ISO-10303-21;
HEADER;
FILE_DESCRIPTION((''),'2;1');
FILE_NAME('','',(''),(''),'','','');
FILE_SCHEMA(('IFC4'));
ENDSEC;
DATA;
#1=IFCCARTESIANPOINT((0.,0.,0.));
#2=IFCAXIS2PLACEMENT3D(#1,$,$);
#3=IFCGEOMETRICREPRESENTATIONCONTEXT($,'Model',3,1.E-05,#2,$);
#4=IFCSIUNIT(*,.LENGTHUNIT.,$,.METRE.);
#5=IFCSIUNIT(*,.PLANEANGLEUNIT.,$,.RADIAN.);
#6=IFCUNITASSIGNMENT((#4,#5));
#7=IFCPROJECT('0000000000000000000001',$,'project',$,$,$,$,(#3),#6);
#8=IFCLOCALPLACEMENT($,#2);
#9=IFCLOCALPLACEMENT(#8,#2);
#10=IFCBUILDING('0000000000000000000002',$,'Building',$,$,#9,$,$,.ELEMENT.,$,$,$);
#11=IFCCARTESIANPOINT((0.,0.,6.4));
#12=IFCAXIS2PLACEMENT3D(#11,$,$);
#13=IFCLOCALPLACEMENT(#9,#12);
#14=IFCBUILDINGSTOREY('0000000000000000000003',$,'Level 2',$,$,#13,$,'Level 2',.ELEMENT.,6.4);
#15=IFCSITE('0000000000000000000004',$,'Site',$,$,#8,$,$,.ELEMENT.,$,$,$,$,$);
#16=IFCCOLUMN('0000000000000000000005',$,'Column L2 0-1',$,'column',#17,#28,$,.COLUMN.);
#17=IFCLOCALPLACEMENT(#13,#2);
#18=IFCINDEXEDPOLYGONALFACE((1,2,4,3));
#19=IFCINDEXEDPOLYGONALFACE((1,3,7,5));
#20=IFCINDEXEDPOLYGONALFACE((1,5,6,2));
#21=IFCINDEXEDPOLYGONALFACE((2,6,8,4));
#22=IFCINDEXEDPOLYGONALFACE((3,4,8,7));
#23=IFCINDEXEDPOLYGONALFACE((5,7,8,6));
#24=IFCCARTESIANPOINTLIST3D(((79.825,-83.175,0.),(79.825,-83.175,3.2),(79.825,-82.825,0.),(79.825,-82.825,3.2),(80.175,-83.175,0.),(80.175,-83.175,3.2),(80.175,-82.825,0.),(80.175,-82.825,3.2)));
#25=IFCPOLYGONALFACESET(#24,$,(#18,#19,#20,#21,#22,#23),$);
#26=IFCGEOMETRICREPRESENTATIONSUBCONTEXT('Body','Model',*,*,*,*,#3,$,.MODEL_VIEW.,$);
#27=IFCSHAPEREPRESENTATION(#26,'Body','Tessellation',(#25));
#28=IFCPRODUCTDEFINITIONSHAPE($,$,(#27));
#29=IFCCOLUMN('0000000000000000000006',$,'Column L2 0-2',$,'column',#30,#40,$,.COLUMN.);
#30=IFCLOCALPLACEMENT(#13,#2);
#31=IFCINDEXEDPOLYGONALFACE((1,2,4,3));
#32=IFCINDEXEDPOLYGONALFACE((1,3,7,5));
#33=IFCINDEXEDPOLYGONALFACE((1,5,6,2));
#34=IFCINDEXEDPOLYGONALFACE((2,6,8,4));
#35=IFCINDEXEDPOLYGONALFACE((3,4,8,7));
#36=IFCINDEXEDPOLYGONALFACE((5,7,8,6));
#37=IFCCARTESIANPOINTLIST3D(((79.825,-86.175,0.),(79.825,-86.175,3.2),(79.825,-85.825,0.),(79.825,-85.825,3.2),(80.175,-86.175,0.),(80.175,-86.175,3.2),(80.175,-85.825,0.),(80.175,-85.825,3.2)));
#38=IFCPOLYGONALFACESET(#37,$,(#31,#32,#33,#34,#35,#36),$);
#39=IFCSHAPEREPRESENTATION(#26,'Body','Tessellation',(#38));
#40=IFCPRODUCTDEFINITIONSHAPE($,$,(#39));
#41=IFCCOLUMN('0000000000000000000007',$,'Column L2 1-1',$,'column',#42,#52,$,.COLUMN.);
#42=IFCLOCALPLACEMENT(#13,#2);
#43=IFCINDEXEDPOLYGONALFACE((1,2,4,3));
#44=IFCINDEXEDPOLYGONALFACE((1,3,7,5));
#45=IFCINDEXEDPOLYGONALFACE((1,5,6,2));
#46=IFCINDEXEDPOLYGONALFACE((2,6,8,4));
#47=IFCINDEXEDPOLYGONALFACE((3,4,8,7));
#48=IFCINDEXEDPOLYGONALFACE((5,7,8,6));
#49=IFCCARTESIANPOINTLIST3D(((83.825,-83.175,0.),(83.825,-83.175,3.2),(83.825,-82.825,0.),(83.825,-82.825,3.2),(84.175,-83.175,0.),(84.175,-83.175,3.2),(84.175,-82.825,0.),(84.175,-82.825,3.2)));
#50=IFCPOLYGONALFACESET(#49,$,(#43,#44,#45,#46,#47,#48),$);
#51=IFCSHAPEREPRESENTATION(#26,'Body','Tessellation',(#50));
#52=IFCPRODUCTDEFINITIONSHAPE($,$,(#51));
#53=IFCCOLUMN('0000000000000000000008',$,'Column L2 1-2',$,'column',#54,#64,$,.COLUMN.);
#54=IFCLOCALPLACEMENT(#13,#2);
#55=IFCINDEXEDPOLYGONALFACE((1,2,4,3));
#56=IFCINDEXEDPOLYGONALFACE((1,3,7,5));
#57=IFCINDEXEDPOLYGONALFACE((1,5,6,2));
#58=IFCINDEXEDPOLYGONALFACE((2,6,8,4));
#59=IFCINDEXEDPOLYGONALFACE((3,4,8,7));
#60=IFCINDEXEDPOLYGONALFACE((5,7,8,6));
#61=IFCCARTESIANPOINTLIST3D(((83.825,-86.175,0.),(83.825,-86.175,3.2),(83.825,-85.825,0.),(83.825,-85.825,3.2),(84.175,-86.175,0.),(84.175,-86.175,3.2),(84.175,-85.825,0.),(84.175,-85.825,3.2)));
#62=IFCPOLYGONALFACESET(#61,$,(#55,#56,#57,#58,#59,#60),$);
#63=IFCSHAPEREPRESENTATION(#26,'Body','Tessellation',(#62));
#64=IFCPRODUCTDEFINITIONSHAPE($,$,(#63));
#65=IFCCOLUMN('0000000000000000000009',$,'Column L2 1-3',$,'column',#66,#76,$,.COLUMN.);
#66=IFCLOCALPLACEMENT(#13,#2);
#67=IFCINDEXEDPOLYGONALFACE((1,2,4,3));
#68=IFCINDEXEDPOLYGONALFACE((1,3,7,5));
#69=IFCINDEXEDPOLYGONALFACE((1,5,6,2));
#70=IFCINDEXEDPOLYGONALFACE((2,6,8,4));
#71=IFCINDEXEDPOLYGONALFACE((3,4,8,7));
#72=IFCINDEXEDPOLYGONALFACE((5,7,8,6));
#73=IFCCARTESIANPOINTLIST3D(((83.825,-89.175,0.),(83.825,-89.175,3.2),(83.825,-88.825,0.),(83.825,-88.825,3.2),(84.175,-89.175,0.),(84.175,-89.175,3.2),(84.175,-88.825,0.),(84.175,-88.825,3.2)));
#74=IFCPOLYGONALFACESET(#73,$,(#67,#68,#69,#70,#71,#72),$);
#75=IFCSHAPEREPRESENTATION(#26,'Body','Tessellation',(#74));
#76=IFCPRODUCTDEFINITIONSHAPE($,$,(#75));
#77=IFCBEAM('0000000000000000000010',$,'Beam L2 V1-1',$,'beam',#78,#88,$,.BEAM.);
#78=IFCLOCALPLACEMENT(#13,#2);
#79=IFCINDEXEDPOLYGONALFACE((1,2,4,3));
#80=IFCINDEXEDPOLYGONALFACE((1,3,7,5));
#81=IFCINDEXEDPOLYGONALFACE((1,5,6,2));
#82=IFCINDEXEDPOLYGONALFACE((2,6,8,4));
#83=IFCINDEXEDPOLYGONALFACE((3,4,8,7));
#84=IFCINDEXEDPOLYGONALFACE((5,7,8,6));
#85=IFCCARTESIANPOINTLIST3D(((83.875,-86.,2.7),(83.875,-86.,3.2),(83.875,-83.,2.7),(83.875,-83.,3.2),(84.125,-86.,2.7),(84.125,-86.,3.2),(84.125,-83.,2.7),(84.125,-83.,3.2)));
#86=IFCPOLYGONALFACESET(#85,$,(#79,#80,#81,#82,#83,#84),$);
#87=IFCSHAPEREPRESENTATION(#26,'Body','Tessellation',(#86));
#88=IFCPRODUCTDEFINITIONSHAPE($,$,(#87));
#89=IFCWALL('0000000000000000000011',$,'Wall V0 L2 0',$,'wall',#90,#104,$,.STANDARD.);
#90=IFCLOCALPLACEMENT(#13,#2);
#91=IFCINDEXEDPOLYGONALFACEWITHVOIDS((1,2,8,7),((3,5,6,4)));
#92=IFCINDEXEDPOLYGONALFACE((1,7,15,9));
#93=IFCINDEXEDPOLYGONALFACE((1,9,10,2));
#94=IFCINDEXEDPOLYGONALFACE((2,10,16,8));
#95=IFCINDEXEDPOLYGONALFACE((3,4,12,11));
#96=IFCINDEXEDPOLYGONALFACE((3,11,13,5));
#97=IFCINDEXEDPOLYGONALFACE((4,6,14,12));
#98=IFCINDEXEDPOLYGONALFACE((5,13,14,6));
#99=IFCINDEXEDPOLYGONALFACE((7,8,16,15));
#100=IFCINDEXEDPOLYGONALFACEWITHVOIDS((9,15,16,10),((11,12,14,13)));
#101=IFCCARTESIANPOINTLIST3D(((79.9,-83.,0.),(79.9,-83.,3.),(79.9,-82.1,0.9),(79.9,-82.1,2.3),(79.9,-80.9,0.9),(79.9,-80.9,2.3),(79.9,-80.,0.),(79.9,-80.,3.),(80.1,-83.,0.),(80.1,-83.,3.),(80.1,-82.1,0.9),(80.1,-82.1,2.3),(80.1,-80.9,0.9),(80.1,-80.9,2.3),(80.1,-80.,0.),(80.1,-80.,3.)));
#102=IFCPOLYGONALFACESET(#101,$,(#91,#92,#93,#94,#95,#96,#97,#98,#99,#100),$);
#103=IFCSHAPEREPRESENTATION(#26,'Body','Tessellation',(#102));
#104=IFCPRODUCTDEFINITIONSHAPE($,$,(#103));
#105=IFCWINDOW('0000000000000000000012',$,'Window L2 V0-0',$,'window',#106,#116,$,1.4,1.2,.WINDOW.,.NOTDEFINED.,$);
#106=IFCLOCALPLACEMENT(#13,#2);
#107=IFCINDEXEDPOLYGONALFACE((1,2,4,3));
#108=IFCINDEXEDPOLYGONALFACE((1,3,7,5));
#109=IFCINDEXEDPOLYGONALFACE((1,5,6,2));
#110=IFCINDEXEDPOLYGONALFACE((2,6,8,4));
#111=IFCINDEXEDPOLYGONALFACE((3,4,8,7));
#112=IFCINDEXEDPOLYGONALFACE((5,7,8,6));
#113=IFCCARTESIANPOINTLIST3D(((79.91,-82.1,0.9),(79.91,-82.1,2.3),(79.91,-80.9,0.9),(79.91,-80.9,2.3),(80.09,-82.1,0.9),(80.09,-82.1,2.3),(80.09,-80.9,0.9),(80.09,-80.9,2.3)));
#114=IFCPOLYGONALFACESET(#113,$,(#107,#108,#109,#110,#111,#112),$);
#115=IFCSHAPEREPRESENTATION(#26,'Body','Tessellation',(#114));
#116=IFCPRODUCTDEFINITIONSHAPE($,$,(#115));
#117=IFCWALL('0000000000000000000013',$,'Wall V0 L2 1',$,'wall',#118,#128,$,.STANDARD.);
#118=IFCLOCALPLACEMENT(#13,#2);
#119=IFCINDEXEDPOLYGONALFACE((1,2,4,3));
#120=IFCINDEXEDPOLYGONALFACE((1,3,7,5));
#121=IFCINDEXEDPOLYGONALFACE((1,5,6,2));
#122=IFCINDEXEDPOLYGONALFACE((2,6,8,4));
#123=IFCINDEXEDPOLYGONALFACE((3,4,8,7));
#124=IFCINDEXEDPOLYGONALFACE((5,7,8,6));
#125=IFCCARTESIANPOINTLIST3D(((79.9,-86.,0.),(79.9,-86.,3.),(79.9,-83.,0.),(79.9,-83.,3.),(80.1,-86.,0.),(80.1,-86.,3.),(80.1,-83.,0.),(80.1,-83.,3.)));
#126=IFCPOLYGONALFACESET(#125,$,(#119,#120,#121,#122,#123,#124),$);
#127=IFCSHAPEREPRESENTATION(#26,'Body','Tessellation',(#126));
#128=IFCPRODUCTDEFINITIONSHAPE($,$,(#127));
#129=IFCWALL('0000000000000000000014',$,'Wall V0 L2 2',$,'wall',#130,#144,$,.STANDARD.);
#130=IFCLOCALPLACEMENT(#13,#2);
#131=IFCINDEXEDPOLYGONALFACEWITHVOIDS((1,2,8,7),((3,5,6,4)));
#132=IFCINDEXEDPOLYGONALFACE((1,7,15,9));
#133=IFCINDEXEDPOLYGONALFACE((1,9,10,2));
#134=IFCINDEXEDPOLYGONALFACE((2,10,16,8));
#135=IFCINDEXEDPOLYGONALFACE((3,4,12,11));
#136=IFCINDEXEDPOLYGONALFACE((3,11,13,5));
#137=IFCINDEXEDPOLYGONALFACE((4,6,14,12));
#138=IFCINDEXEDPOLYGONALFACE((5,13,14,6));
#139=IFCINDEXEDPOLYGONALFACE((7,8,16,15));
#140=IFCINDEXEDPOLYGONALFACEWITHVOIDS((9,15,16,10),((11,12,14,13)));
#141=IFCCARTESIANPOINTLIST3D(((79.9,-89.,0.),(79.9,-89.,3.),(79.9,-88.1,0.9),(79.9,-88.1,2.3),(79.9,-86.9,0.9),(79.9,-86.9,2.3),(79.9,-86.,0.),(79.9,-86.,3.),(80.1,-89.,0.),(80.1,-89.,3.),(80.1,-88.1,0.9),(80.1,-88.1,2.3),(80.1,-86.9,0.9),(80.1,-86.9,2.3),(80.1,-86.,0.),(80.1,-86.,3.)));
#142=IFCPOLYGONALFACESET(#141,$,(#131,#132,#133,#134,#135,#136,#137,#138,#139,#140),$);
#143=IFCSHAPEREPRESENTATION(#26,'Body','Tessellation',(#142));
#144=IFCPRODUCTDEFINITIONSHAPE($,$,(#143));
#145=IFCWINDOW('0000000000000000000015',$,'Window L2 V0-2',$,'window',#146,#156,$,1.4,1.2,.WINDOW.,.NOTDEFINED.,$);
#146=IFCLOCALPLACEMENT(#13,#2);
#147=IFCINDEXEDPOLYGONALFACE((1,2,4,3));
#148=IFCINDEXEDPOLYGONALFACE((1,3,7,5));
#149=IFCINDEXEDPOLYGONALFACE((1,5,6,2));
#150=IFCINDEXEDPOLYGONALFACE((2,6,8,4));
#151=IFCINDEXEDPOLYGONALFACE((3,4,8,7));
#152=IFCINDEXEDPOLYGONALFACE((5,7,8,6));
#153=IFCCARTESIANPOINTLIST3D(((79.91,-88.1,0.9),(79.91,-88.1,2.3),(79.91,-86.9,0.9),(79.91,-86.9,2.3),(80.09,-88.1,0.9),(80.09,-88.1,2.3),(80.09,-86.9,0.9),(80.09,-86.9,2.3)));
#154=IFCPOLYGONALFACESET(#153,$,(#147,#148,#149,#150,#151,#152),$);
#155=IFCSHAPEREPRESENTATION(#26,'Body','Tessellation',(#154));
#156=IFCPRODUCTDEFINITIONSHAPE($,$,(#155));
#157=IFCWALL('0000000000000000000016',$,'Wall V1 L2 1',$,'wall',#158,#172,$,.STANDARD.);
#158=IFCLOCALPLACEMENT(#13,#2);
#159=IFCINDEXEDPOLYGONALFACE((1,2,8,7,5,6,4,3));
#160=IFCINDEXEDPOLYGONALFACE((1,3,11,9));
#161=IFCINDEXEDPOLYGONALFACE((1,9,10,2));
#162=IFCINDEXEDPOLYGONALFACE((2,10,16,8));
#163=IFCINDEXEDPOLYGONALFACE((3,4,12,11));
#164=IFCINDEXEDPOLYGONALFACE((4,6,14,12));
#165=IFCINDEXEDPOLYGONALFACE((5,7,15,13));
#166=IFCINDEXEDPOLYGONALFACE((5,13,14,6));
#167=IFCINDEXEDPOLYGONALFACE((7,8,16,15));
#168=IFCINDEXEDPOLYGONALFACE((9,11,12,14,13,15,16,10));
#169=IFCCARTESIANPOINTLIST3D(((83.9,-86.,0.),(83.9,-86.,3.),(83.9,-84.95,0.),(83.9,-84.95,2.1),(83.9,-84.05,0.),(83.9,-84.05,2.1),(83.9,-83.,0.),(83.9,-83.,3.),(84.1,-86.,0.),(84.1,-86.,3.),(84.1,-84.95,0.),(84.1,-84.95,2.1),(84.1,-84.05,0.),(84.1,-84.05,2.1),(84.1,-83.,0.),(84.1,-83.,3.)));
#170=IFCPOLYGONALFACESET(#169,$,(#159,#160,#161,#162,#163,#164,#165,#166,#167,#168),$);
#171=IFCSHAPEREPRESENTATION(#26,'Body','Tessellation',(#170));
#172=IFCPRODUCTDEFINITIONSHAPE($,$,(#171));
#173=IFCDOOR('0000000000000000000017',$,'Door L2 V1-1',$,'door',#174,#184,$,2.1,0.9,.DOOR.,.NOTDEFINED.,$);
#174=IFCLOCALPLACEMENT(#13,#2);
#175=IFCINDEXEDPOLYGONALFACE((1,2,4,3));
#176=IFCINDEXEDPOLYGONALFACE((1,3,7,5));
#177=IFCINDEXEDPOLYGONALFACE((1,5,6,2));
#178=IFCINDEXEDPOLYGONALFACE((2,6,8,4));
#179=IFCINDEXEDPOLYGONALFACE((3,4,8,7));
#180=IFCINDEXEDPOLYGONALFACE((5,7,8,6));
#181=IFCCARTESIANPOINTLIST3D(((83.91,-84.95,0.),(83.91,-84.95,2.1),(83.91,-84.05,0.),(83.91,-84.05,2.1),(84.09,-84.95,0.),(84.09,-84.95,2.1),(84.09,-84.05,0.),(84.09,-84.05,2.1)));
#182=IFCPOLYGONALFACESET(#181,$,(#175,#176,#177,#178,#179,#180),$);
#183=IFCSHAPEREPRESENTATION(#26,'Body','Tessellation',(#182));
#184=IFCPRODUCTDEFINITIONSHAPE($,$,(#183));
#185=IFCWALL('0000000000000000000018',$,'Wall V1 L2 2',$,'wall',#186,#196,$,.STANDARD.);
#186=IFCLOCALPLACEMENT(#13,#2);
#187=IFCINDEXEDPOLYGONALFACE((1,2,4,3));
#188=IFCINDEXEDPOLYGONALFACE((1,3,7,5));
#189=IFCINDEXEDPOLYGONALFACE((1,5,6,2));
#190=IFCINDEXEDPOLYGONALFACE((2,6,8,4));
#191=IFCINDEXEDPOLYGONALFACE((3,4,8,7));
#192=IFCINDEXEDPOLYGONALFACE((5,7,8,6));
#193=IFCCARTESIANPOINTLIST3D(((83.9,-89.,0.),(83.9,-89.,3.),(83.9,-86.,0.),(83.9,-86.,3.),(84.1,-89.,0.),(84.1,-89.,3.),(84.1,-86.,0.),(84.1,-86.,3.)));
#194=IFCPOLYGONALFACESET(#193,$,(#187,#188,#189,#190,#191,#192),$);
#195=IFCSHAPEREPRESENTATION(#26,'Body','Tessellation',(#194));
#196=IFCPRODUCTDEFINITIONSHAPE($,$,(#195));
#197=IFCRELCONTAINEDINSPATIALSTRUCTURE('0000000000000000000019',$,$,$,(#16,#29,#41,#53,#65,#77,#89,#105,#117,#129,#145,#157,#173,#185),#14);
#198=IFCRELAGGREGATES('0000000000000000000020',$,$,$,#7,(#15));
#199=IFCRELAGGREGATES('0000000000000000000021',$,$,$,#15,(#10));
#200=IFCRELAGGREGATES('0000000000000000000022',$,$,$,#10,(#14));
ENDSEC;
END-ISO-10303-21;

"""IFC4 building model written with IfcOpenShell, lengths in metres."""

from ifc_helpers import new_model, si_unit, frame, frame_2d, origin, origin_2d, place, context, subcontext, project, spatial, rectangle, extrude, element, fill, save


model = new_model("IFC4")

# Units and contexts
model_context = context("Model", 3, precision=1e-05, world=origin())
body_context = subcontext(model_context, "Body", "Model", "MODEL_VIEW")
ifc_project = project(units=[si_unit("LENGTHUNIT", "METRE"), si_unit("PLANEANGLEUNIT", "RADIAN")], contexts=[model_context])

# Site, building, storey
site_placement = place(None, origin())
site = spatial("IfcSite", under=ifc_project, at=site_placement, Name="Site", CompositionType="ELEMENT")
building_placement = place(site_placement, origin())
building = spatial("IfcBuilding", under=site, at=building_placement, Name="Building", CompositionType="ELEMENT")
storey_placement = place(building_placement, frame((0.0, 0.0, 6.4)))
storey = spatial("IfcBuildingStorey", under=building, at=storey_placement, Name="Level 2", LongName="Level 2", CompositionType="ELEMENT", Elevation=6.4)

# Columns
for number, where, name in (
    (1, (80.0, -83.0, 0.0), "Column L2 0-1"),
    (2, (80.0, -86.0, 0.0), "Column L2 0-2"),
    (3, (84.0, -83.0, 0.0), "Column L2 1-1"),
    (4, (84.0, -86.0, 0.0), "Column L2 1-2"),
    (5, (84.0, -89.0, 0.0), "Column L2 1-3"),
):
    element("IfcColumn", number, at=place(storey_placement, frame(where)), inside=storey, Name=name, ObjectType="column", PredefinedType="COLUMN", context=body_context, shape_type="SweptSolid", body=[
        extrude(rectangle(XDim=0.35, YDim=0.35, at=origin_2d()), origin(), (0.0, 0.0, 1.0), 3.2),
    ])

# Beam
beam_placement = place(storey_placement, frame((84.0, -83.0, 2.95), z_axis=(0.0, -1.0, 0.0), x_axis=(0.0, 0.0, 1.0)))
element("IfcBeam", 6, at=beam_placement, inside=storey, Name="Beam L2 V1-1", ObjectType="beam", PredefinedType="BEAM", context=body_context, shape_type="SweptSolid", body=[
    extrude(rectangle(XDim=0.5, YDim=0.25, at=origin_2d()), origin(), (0.0, 0.0, 1.0), 3.0),
])

# Wall, opening, window
wall_1_placement = place(storey_placement, frame((80.0, -80.0, 0.0), z_axis=(0.0, 0.0, 1.0), x_axis=(0.0, -1.0, 0.0)))
wall_1 = element("IfcWall", 7, at=wall_1_placement, inside=storey, Name="Wall V0 L2 0", ObjectType="wall", PredefinedType="STANDARD", context=body_context, shape_type="SweptSolid", body=[
    extrude(rectangle(XDim=3.0, YDim=0.2, at=frame_2d((1.5, 0.0))), origin(), (0.0, 0.0, 1.0), 3.0),
])
opening_1_placement = place(storey_placement, frame((80.0, -81.5, 0.9), z_axis=(0.0, 0.0, 1.0), x_axis=(0.0, -1.0, 0.0)))
opening_1 = element("IfcOpeningElement", 8, at=opening_1_placement, cuts=wall_1, ObjectType="Opening", PredefinedType="OPENING", context=body_context, shape_type="SweptSolid", body=[
    extrude(rectangle(XDim=1.2, YDim=0.22, at=origin_2d()), origin(), (0.0, 0.0, 1.0), 1.4),
])
window_1_placement = place(storey_placement, frame((80.0, -81.5, 0.9), z_axis=(0.0, 0.0, 1.0), x_axis=(0.0, -1.0, 0.0)))
window_1 = element("IfcWindow", 9, at=window_1_placement, inside=storey, Name="Window L2 V0-0", ObjectType="window", OverallHeight=1.4, OverallWidth=1.2, PartitioningType="NOTDEFINED", PredefinedType="WINDOW", context=body_context, shape_type="SweptSolid", body=[
    extrude(rectangle(XDim=1.2, YDim=0.18, at=origin_2d()), origin(), (0.0, 0.0, 1.0), 1.4),
])
fill(opening_1, window_1)

# Wall
wall_2_placement = place(storey_placement, frame((80.0, -83.0, 0.0), z_axis=(0.0, 0.0, 1.0), x_axis=(0.0, -1.0, 0.0)))
element("IfcWall", 10, at=wall_2_placement, inside=storey, Name="Wall V0 L2 1", ObjectType="wall", PredefinedType="STANDARD", context=body_context, shape_type="SweptSolid", body=[
    extrude(rectangle(XDim=3.0, YDim=0.2, at=frame_2d((1.5, 0.0))), origin(), (0.0, 0.0, 1.0), 3.0),
])

# Wall, opening, window
wall_3_placement = place(storey_placement, frame((80.0, -86.0, 0.0), z_axis=(0.0, 0.0, 1.0), x_axis=(0.0, -1.0, 0.0)))
wall_3 = element("IfcWall", 11, at=wall_3_placement, inside=storey, Name="Wall V0 L2 2", ObjectType="wall", PredefinedType="STANDARD", context=body_context, shape_type="SweptSolid", body=[
    extrude(rectangle(XDim=3.0, YDim=0.2, at=frame_2d((1.5, 0.0))), origin(), (0.0, 0.0, 1.0), 3.0),
])
opening_2_placement = place(storey_placement, frame((80.0, -87.5, 0.9), z_axis=(0.0, 0.0, 1.0), x_axis=(0.0, -1.0, 0.0)))
opening_2 = element("IfcOpeningElement", 12, at=opening_2_placement, cuts=wall_3, ObjectType="Opening", PredefinedType="OPENING", context=body_context, shape_type="SweptSolid", body=[
    extrude(rectangle(XDim=1.2, YDim=0.22, at=origin_2d()), origin(), (0.0, 0.0, 1.0), 1.4),
])
window_2_placement = place(storey_placement, frame((80.0, -87.5, 0.9), z_axis=(0.0, 0.0, 1.0), x_axis=(0.0, -1.0, 0.0)))
window_2 = element("IfcWindow", 13, at=window_2_placement, inside=storey, Name="Window L2 V0-2", ObjectType="window", OverallHeight=1.4, OverallWidth=1.2, PartitioningType="NOTDEFINED", PredefinedType="WINDOW", context=body_context, shape_type="SweptSolid", body=[
    extrude(rectangle(XDim=1.2, YDim=0.18, at=origin_2d()), origin(), (0.0, 0.0, 1.0), 1.4),
])
fill(opening_2, window_2)

# Wall, opening, door
wall_4_placement = place(storey_placement, frame((84.0, -83.0, 0.0), z_axis=(0.0, 0.0, 1.0), x_axis=(0.0, -1.0, 0.0)))
wall_4 = element("IfcWall", 14, at=wall_4_placement, inside=storey, Name="Wall V1 L2 1", ObjectType="wall", PredefinedType="STANDARD", context=body_context, shape_type="SweptSolid", body=[
    extrude(rectangle(XDim=3.0, YDim=0.2, at=frame_2d((1.5, 0.0))), origin(), (0.0, 0.0, 1.0), 3.0),
])
opening_3_placement = place(storey_placement, frame((84.0, -84.5, 0.0), z_axis=(0.0, 0.0, 1.0), x_axis=(0.0, -1.0, 0.0)))
opening_3 = element("IfcOpeningElement", 15, at=opening_3_placement, cuts=wall_4, ObjectType="Opening", PredefinedType="OPENING", context=body_context, shape_type="SweptSolid", body=[
    extrude(rectangle(XDim=0.9, YDim=0.22, at=origin_2d()), origin(), (0.0, 0.0, 1.0), 2.1),
])
door_placement = place(storey_placement, frame((84.0, -84.5, 0.0), z_axis=(0.0, 0.0, 1.0), x_axis=(0.0, -1.0, 0.0)))
door = element("IfcDoor", 16, at=door_placement, inside=storey, Name="Door L2 V1-1", ObjectType="door", OperationType="NOTDEFINED", OverallHeight=2.1, OverallWidth=0.9, PredefinedType="DOOR", context=body_context, shape_type="SweptSolid", body=[
    extrude(rectangle(XDim=0.9, YDim=0.18, at=origin_2d()), origin(), (0.0, 0.0, 1.0), 2.1),
])
fill(opening_3, door)

# Wall
wall_5_placement = place(storey_placement, frame((84.0, -86.0, 0.0), z_axis=(0.0, 0.0, 1.0), x_axis=(0.0, -1.0, 0.0)))
element("IfcWall", 17, at=wall_5_placement, inside=storey, Name="Wall V1 L2 2", ObjectType="wall", PredefinedType="STANDARD", context=body_context, shape_type="SweptSolid", body=[
    extrude(rectangle(XDim=3.0, YDim=0.2, at=frame_2d((1.5, 0.0))), origin(), (0.0, 0.0, 1.0), 3.0),
])

save(model, "model.ifc")
